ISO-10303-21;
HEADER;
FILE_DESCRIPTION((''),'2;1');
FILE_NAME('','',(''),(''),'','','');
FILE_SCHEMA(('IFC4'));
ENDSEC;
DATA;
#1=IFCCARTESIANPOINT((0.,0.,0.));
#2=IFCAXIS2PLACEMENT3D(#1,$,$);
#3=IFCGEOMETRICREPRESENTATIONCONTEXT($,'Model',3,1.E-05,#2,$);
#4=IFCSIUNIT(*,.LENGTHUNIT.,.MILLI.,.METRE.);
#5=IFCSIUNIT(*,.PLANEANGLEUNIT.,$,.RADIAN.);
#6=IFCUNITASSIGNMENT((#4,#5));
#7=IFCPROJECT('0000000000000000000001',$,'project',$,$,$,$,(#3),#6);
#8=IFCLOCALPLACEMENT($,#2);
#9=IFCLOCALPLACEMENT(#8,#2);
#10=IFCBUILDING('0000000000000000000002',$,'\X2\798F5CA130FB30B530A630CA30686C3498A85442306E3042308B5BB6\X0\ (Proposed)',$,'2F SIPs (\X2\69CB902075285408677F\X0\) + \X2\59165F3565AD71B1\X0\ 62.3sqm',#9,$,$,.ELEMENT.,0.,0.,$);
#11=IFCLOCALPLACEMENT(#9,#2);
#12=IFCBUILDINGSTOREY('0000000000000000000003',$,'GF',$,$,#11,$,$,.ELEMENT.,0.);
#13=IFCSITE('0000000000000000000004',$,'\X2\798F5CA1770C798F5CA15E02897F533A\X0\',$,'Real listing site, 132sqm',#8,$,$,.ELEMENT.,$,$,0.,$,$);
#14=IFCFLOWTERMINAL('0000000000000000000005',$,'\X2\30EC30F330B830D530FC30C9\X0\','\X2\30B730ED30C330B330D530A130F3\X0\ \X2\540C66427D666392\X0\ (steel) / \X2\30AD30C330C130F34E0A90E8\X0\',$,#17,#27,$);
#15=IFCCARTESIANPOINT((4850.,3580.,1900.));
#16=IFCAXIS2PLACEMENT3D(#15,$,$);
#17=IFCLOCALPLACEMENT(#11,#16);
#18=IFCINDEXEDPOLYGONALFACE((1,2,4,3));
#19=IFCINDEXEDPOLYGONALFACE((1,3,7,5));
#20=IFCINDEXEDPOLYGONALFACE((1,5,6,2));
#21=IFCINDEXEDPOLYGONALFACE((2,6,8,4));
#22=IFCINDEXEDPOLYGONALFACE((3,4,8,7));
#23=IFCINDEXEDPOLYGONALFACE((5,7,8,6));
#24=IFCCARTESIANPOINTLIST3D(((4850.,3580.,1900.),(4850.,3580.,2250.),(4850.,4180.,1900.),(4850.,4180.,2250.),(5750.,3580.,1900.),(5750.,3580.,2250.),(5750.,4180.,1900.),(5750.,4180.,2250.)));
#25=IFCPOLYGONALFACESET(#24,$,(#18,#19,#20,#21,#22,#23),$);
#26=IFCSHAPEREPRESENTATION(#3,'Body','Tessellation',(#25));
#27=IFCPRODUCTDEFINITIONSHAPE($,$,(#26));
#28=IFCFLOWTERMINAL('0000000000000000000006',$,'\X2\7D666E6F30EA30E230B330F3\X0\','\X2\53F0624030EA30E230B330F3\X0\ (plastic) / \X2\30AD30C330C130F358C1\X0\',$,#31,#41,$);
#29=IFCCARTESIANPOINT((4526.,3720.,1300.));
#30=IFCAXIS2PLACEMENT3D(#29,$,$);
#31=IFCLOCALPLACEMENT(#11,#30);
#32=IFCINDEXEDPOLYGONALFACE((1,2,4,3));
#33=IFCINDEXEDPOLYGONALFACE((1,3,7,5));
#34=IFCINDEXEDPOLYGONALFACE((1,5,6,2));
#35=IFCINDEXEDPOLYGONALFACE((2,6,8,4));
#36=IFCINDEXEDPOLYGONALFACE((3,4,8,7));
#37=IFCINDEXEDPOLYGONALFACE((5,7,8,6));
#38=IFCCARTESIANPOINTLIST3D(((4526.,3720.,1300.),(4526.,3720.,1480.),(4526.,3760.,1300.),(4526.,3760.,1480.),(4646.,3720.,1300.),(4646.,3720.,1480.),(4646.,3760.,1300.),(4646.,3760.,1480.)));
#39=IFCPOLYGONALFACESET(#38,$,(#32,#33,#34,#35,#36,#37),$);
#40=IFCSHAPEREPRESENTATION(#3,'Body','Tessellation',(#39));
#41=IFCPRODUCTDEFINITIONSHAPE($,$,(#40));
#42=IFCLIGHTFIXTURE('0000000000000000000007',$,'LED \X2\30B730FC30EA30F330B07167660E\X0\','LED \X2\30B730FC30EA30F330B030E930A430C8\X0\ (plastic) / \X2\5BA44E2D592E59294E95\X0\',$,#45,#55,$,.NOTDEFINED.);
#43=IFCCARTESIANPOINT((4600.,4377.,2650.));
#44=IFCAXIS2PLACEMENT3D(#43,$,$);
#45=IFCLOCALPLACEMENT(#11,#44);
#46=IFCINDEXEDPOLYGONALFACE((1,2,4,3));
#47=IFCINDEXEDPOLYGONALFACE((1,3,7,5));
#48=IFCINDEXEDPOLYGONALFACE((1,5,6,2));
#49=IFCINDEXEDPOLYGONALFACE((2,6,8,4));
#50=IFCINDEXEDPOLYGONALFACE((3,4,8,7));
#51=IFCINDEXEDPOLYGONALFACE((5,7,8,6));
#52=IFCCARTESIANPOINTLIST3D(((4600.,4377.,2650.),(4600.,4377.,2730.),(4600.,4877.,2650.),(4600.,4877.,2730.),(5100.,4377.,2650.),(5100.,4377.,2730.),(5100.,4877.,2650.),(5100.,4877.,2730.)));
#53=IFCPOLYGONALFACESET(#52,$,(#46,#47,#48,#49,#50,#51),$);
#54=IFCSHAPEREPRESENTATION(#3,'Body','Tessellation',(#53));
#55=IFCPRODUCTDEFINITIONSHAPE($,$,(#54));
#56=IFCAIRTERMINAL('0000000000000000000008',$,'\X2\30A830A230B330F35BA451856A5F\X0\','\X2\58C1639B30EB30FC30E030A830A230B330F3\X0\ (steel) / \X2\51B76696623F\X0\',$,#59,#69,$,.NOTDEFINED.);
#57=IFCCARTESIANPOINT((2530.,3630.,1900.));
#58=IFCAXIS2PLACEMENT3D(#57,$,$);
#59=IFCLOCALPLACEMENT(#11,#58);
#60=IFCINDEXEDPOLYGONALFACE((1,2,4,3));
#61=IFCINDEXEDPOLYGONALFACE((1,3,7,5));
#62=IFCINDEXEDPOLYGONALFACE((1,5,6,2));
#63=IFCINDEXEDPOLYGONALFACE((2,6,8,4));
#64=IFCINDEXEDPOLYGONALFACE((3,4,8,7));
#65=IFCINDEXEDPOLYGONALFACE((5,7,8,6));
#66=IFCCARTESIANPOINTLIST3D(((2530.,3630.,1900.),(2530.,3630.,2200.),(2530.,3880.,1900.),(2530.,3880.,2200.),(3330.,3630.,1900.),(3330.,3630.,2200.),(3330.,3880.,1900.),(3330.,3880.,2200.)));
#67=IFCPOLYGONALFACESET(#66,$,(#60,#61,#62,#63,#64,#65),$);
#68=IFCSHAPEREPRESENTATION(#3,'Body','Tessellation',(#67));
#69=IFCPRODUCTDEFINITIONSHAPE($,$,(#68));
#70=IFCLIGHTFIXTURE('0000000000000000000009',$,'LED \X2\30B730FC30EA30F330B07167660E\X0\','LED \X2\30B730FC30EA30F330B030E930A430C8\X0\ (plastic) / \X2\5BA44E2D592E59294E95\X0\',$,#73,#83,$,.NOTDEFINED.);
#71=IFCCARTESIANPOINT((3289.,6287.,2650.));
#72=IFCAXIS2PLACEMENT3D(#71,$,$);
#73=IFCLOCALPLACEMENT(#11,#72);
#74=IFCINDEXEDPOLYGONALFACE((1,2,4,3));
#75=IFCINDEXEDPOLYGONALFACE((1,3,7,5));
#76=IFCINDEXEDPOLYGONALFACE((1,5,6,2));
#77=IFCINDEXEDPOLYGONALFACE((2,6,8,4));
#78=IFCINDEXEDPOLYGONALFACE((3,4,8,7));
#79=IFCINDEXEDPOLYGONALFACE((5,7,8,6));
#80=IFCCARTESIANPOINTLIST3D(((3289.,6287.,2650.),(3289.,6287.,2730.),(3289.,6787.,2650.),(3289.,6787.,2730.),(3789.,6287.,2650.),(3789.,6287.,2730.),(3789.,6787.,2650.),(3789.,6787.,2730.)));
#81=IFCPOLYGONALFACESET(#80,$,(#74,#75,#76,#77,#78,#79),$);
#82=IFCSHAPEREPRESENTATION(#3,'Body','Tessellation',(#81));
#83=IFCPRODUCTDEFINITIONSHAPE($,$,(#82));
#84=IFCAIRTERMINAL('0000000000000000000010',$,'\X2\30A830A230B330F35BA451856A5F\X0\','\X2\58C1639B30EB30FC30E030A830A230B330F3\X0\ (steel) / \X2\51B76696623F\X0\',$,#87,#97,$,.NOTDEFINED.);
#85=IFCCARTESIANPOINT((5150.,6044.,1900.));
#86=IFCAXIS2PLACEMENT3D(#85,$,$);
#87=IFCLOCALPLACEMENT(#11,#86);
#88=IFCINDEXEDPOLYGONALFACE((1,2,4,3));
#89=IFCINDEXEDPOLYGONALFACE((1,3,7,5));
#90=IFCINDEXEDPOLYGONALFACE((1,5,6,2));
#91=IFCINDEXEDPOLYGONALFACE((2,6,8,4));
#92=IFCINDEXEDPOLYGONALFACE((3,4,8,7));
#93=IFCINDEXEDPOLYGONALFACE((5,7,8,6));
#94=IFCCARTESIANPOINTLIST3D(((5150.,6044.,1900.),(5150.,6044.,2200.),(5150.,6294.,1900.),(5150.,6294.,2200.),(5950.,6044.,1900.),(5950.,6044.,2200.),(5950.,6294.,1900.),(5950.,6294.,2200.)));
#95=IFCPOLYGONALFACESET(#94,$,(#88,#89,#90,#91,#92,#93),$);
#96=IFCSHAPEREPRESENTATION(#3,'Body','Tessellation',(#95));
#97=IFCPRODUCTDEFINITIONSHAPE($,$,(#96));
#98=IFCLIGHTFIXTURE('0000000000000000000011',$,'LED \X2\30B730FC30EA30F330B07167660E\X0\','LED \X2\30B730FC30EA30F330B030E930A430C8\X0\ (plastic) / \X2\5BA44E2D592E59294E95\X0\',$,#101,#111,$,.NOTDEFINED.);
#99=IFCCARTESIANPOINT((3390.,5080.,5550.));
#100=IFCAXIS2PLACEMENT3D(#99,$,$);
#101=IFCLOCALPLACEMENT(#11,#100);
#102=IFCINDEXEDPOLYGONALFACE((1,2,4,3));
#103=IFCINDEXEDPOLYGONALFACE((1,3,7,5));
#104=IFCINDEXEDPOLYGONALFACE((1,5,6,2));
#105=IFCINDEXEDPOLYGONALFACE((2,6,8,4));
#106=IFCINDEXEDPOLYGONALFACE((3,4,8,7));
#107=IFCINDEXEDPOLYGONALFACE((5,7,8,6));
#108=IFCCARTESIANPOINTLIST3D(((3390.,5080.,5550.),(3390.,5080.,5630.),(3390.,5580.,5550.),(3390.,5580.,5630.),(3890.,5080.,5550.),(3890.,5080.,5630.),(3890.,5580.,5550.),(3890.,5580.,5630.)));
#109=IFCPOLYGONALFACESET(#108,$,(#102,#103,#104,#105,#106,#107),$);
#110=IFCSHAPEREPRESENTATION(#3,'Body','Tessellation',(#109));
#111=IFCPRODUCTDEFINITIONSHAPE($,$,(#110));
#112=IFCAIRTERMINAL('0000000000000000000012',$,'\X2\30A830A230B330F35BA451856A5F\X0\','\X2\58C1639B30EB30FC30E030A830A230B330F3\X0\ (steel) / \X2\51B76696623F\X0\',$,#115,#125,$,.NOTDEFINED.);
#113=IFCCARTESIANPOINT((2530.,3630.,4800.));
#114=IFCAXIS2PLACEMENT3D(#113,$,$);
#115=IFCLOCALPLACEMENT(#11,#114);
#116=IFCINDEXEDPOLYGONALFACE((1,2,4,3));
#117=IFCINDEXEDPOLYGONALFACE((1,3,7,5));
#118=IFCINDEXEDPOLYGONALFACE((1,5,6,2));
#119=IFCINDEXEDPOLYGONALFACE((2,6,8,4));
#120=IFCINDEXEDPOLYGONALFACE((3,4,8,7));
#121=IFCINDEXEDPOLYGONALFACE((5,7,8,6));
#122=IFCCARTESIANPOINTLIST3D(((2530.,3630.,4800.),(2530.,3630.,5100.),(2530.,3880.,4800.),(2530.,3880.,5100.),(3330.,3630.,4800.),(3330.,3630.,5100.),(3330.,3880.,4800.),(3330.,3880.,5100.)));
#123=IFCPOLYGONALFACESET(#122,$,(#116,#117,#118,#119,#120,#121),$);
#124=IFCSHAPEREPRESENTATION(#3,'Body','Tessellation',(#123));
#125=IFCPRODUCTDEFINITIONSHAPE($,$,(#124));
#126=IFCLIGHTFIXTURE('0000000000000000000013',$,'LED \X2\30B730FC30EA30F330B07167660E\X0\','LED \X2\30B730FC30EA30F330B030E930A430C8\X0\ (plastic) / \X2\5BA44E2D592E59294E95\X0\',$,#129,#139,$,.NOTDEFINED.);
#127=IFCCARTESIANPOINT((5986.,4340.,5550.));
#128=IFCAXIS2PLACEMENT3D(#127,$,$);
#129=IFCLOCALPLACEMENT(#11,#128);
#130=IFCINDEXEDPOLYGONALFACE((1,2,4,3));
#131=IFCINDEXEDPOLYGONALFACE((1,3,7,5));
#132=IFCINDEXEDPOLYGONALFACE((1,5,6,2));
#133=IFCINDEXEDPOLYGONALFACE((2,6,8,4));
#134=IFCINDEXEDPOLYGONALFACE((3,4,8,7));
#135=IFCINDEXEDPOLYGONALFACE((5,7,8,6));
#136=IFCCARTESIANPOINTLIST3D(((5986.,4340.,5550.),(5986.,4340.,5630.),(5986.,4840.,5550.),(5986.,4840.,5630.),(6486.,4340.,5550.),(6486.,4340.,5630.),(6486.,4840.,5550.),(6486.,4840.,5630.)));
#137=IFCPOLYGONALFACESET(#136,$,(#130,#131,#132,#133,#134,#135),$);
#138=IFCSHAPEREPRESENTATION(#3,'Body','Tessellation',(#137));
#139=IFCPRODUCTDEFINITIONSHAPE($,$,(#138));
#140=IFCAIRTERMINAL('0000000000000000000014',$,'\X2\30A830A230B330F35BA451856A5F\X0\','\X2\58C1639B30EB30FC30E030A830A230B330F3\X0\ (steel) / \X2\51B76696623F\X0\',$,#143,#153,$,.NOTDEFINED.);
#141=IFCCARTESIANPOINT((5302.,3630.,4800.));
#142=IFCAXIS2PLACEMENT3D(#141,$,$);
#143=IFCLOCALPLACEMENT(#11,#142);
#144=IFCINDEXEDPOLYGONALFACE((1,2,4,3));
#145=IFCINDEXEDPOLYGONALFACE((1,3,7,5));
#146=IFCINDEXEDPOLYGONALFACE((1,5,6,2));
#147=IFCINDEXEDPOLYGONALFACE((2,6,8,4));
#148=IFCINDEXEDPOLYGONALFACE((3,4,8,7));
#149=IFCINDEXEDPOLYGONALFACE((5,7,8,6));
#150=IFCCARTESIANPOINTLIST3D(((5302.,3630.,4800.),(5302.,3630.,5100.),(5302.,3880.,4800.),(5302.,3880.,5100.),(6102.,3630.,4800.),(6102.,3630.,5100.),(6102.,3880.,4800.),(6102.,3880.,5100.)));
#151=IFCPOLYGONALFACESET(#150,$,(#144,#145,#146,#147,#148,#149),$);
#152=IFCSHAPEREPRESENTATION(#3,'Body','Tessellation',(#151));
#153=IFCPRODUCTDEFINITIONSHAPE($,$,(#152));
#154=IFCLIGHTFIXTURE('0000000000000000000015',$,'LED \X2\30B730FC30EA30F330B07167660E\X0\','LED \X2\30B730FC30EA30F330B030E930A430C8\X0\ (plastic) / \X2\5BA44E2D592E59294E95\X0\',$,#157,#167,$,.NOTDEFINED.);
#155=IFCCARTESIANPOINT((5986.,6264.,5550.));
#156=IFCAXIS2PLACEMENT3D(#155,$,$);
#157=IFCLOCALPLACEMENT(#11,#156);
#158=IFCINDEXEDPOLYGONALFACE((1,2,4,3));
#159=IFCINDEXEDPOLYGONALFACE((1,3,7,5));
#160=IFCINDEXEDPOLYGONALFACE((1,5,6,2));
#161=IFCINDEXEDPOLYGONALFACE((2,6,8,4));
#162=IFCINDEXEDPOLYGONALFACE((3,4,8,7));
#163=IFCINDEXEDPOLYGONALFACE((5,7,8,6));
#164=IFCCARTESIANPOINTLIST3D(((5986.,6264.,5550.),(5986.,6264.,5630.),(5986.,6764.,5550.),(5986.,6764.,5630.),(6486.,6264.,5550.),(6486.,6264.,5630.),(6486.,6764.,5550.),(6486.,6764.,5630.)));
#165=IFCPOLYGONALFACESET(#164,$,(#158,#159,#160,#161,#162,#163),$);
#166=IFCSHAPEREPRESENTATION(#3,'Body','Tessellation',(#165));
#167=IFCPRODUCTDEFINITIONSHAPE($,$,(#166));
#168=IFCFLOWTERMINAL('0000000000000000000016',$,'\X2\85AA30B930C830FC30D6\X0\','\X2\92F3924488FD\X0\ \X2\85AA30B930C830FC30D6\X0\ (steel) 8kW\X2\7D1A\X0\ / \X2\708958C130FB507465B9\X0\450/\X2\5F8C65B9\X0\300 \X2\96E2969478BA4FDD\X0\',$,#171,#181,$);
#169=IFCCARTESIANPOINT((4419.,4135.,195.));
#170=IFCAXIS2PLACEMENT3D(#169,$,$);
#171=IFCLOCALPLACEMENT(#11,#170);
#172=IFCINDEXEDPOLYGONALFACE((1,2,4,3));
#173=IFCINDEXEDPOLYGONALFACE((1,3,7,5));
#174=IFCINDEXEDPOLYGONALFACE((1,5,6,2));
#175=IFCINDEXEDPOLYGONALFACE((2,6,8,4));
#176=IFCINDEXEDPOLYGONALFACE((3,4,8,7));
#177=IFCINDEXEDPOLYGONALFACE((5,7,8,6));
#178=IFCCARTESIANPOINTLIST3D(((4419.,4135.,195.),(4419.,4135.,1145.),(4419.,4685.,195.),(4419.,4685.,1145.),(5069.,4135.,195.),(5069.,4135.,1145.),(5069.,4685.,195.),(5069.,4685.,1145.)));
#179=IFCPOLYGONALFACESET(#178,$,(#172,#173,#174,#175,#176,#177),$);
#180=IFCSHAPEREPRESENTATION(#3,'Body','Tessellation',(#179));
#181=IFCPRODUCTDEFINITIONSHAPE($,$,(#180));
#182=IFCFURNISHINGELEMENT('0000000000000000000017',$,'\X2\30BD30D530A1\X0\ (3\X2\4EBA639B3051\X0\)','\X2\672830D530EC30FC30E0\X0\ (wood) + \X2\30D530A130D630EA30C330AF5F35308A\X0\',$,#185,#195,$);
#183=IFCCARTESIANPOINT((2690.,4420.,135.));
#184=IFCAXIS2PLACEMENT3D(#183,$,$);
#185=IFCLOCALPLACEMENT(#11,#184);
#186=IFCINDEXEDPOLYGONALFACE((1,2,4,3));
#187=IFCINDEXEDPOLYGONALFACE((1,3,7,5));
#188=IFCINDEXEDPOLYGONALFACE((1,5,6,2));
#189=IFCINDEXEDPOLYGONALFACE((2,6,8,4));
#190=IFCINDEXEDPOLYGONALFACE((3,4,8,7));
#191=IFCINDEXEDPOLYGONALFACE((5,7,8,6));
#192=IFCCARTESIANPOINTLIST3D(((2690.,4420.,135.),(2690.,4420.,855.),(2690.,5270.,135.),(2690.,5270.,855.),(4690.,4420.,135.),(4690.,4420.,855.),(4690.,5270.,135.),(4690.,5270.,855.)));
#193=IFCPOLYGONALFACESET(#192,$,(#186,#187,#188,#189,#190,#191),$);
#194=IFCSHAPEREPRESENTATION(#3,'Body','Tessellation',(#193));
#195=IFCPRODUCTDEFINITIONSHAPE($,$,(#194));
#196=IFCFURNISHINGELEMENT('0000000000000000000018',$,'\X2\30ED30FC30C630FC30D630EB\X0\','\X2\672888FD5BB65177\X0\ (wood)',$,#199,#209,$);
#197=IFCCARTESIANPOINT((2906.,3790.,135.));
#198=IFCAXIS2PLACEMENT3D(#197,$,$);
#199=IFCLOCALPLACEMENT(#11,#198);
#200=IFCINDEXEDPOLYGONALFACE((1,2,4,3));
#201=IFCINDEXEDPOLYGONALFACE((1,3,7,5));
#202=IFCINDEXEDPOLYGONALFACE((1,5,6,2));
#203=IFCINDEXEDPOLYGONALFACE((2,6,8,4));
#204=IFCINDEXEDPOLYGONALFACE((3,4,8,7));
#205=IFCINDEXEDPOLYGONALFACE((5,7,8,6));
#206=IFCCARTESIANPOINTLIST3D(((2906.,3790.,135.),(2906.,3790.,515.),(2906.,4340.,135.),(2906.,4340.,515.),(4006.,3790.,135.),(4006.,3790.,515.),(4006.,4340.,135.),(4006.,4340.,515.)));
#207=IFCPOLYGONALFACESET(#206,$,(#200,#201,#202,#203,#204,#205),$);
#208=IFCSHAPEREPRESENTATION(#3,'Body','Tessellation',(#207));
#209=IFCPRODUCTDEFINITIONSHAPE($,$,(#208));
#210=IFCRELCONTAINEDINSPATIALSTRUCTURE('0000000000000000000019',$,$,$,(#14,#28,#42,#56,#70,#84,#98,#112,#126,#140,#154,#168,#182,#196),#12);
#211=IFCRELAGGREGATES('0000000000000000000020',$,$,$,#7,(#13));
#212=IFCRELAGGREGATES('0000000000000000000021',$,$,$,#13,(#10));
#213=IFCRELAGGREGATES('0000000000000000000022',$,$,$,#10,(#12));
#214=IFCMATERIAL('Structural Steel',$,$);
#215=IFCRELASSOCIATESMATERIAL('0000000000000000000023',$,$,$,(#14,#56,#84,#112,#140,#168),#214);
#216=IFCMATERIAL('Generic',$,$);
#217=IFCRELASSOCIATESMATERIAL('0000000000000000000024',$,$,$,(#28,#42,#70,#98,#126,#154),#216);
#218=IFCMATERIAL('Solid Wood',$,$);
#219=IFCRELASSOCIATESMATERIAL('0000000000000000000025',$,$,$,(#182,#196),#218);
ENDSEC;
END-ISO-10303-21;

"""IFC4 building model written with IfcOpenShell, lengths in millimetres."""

from ifc_helpers import new_model, si_unit, frame, frame_2d, origin, place, context, project, spatial, rectangle, extrude, material, element, save


model = new_model("IFC4")

# Units and contexts
model_context = context("Model", 3, precision=1e-05, world=origin())
ifc_project = project(units=[si_unit("LENGTHUNIT", "METRE", prefix="MILLI"), si_unit("PLANEANGLEUNIT", "RADIAN")], contexts=[model_context])

# Site, building, storey
site_placement = place(None, origin())
site = spatial("IfcSite", under=ifc_project, at=site_placement, Name="福岡県福岡市西区", ObjectType="Real listing site, 132sqm", CompositionType="ELEMENT", RefElevation=0.0)
building_placement = place(site_placement, origin())
building = spatial("IfcBuilding", under=site, at=building_placement, Name="福岡・サウナと水風呂のある家 (Proposed)", ObjectType="2F SIPs (構造用合板) + 外張断熱 62.3sqm", CompositionType="ELEMENT", ElevationOfRefHeight=0.0, ElevationOfTerrain=0.0)
storey_placement = place(building_placement, origin())
storey = spatial("IfcBuildingStorey", under=building, at=storey_placement, Name="GF", CompositionType="ELEMENT", Elevation=0.0)

# Shared definitions
ifc_material_1 = material(Name="Solid Wood")

# Shared definitions
ifc_material_2 = material(Name="Structural Steel")

# Flow terminals
flow_terminal_1_placement = place(storey_placement, frame((4850.0, 3580.0, 1900.0)))
element("IfcFlowTerminal", 1, at=flow_terminal_1_placement, inside=storey, material=ifc_material_2, Name="レンジフード", Description="シロッコファン 同時給排 (steel) / キッチン上部", context=model_context, shape_type="SweptSolid", body=[
    extrude(rectangle(XDim=900.0, YDim=600.0, at=frame_2d((450.0, 300.0))), frame((4850.0, 3580.0, 1900.0)), (0.0, 0.0, 1.0), 350.0),
])
ifc_material_3 = material(Name="Generic")
flow_terminal_2_placement = place(storey_placement, frame((4526.0, 3720.0, 1300.0)))
element("IfcFlowTerminal", 2, at=flow_terminal_2_placement, inside=storey, material=ifc_material_3, Name="給湯リモコン", Description="台所リモコン (plastic) / キッチン壁", context=model_context, shape_type="SweptSolid", body=[
    extrude(rectangle(XDim=120.0, YDim=40.0, at=frame_2d((60.0, 20.0))), frame((4526.0, 3720.0, 1300.0)), (0.0, 0.0, 1.0), 180.0),
])

# Light fixture
light_fixture_1_placement = place(storey_placement, frame((4600.0, 4377.0, 2650.0)))
element("IfcLightFixture", 3, at=light_fixture_1_placement, inside=storey, material=ifc_material_3, Name="LED シーリング照明", Description="LED シーリングライト (plastic) / 室中央天井", PredefinedType="NOTDEFINED", context=model_context, shape_type="SweptSolid", body=[
    extrude(rectangle(XDim=500.0, YDim=500.0, at=frame_2d((250.0, 250.0))), frame((4600.0, 4377.0, 2650.0)), (0.0, 0.0, 1.0), 80.0),
])

# Air terminal
air_terminal_1_placement = place(storey_placement, frame((2530.0, 3630.0, 1900.0)))
element("IfcAirTerminal", 4, at=air_terminal_1_placement, inside=storey, material=ifc_material_2, Name="エアコン室内機", Description="壁掛ルームエアコン (steel) / 冷暖房", PredefinedType="NOTDEFINED", context=model_context, shape_type="SweptSolid", body=[
    extrude(rectangle(XDim=800.0, YDim=250.0, at=frame_2d((400.0, 125.0))), frame((2530.0, 3630.0, 1900.0)), (0.0, 0.0, 1.0), 300.0),
])

# Light fixture
light_fixture_2_placement = place(storey_placement, frame((3289.0, 6287.0, 2650.0)))
element("IfcLightFixture", 5, at=light_fixture_2_placement, inside=storey, material=ifc_material_3, Name="LED シーリング照明", Description="LED シーリングライト (plastic) / 室中央天井", PredefinedType="NOTDEFINED", context=model_context, shape_type="SweptSolid", body=[
    extrude(rectangle(XDim=500.0, YDim=500.0, at=frame_2d((250.0, 250.0))), frame((3289.0, 6287.0, 2650.0)), (0.0, 0.0, 1.0), 80.0),
])

# Air terminal
air_terminal_2_placement = place(storey_placement, frame((5150.0, 6044.0, 1900.0)))
element("IfcAirTerminal", 6, at=air_terminal_2_placement, inside=storey, material=ifc_material_2, Name="エアコン室内機", Description="壁掛ルームエアコン (steel) / 冷暖房", PredefinedType="NOTDEFINED", context=model_context, shape_type="SweptSolid", body=[
    extrude(rectangle(XDim=800.0, YDim=250.0, at=frame_2d((400.0, 125.0))), frame((5150.0, 6044.0, 1900.0)), (0.0, 0.0, 1.0), 300.0),
])

# Light fixture
light_fixture_3_placement = place(storey_placement, frame((3390.0, 5080.0, 5550.0)))
element("IfcLightFixture", 7, at=light_fixture_3_placement, inside=storey, material=ifc_material_3, Name="LED シーリング照明", Description="LED シーリングライト (plastic) / 室中央天井", PredefinedType="NOTDEFINED", context=model_context, shape_type="SweptSolid", body=[
    extrude(rectangle(XDim=500.0, YDim=500.0, at=frame_2d((250.0, 250.0))), frame((3390.0, 5080.0, 5550.0)), (0.0, 0.0, 1.0), 80.0),
])

# Air terminal
air_terminal_3_placement = place(storey_placement, frame((2530.0, 3630.0, 4800.0)))
element("IfcAirTerminal", 8, at=air_terminal_3_placement, inside=storey, material=ifc_material_2, Name="エアコン室内機", Description="壁掛ルームエアコン (steel) / 冷暖房", PredefinedType="NOTDEFINED", context=model_context, shape_type="SweptSolid", body=[
    extrude(rectangle(XDim=800.0, YDim=250.0, at=frame_2d((400.0, 125.0))), frame((2530.0, 3630.0, 4800.0)), (0.0, 0.0, 1.0), 300.0),
])

# Light fixture
light_fixture_4_placement = place(storey_placement, frame((5986.0, 4340.0, 5550.0)))
element("IfcLightFixture", 9, at=light_fixture_4_placement, inside=storey, material=ifc_material_3, Name="LED シーリング照明", Description="LED シーリングライト (plastic) / 室中央天井", PredefinedType="NOTDEFINED", context=model_context, shape_type="SweptSolid", body=[
    extrude(rectangle(XDim=500.0, YDim=500.0, at=frame_2d((250.0, 250.0))), frame((5986.0, 4340.0, 5550.0)), (0.0, 0.0, 1.0), 80.0),
])

# Air terminal
air_terminal_4_placement = place(storey_placement, frame((5302.0, 3630.0, 4800.0)))
element("IfcAirTerminal", 10, at=air_terminal_4_placement, inside=storey, material=ifc_material_2, Name="エアコン室内機", Description="壁掛ルームエアコン (steel) / 冷暖房", PredefinedType="NOTDEFINED", context=model_context, shape_type="SweptSolid", body=[
    extrude(rectangle(XDim=800.0, YDim=250.0, at=frame_2d((400.0, 125.0))), frame((5302.0, 3630.0, 4800.0)), (0.0, 0.0, 1.0), 300.0),
])

# Light fixture
light_fixture_5_placement = place(storey_placement, frame((5986.0, 6264.0, 5550.0)))
element("IfcLightFixture", 11, at=light_fixture_5_placement, inside=storey, material=ifc_material_3, Name="LED シーリング照明", Description="LED シーリングライト (plastic) / 室中央天井", PredefinedType="NOTDEFINED", context=model_context, shape_type="SweptSolid", body=[
    extrude(rectangle(XDim=500.0, YDim=500.0, at=frame_2d((250.0, 250.0))), frame((5986.0, 6264.0, 5550.0)), (0.0, 0.0, 1.0), 80.0),
])

# Flow terminal
flow_terminal_3_placement = place(storey_placement, frame((4419.0, 4135.0, 195.0)))
element("IfcFlowTerminal", 12, at=flow_terminal_3_placement, inside=storey, material=ifc_material_2, Name="薪ストーブ", Description="鋳鉄製 薪ストーブ (steel) 8kW級 / 炉壁・側方450/後方300 離隔確保", context=model_context, shape_type="SweptSolid", body=[
    extrude(rectangle(XDim=650.0, YDim=550.0, at=frame_2d((325.0, 275.0))), frame((4419.0, 4135.0, 195.0)), (0.0, 0.0, 1.0), 950.0),
])

# Furnishing elements
furnishing_1_placement = place(storey_placement, frame((2690.0, 4420.0, 135.0)))
element("IfcFurnishingElement", 13, at=furnishing_1_placement, inside=storey, material=ifc_material_1, Name="ソファ (3人掛け)", Description="木フレーム (wood) + ファブリック張り", context=model_context, shape_type="SweptSolid", body=[
    extrude(rectangle(XDim=2000.0, YDim=850.0, at=frame_2d((1000.0, 425.0))), frame((2690.0, 4420.0, 135.0)), (0.0, 0.0, 1.0), 720.0),
])
furnishing_2_placement = place(storey_placement, frame((2906.0, 3790.0, 135.0)))
element("IfcFurnishingElement", 14, at=furnishing_2_placement, inside=storey, material=ifc_material_1, Name="ローテーブル", Description="木製家具 (wood)", context=model_context, shape_type="SweptSolid", body=[
    extrude(rectangle(XDim=1100.0, YDim=550.0, at=frame_2d((550.0, 275.0))), frame((2906.0, 3790.0, 135.0)), (0.0, 0.0, 1.0), 380.0),
])

save(model, "model.ifc")
